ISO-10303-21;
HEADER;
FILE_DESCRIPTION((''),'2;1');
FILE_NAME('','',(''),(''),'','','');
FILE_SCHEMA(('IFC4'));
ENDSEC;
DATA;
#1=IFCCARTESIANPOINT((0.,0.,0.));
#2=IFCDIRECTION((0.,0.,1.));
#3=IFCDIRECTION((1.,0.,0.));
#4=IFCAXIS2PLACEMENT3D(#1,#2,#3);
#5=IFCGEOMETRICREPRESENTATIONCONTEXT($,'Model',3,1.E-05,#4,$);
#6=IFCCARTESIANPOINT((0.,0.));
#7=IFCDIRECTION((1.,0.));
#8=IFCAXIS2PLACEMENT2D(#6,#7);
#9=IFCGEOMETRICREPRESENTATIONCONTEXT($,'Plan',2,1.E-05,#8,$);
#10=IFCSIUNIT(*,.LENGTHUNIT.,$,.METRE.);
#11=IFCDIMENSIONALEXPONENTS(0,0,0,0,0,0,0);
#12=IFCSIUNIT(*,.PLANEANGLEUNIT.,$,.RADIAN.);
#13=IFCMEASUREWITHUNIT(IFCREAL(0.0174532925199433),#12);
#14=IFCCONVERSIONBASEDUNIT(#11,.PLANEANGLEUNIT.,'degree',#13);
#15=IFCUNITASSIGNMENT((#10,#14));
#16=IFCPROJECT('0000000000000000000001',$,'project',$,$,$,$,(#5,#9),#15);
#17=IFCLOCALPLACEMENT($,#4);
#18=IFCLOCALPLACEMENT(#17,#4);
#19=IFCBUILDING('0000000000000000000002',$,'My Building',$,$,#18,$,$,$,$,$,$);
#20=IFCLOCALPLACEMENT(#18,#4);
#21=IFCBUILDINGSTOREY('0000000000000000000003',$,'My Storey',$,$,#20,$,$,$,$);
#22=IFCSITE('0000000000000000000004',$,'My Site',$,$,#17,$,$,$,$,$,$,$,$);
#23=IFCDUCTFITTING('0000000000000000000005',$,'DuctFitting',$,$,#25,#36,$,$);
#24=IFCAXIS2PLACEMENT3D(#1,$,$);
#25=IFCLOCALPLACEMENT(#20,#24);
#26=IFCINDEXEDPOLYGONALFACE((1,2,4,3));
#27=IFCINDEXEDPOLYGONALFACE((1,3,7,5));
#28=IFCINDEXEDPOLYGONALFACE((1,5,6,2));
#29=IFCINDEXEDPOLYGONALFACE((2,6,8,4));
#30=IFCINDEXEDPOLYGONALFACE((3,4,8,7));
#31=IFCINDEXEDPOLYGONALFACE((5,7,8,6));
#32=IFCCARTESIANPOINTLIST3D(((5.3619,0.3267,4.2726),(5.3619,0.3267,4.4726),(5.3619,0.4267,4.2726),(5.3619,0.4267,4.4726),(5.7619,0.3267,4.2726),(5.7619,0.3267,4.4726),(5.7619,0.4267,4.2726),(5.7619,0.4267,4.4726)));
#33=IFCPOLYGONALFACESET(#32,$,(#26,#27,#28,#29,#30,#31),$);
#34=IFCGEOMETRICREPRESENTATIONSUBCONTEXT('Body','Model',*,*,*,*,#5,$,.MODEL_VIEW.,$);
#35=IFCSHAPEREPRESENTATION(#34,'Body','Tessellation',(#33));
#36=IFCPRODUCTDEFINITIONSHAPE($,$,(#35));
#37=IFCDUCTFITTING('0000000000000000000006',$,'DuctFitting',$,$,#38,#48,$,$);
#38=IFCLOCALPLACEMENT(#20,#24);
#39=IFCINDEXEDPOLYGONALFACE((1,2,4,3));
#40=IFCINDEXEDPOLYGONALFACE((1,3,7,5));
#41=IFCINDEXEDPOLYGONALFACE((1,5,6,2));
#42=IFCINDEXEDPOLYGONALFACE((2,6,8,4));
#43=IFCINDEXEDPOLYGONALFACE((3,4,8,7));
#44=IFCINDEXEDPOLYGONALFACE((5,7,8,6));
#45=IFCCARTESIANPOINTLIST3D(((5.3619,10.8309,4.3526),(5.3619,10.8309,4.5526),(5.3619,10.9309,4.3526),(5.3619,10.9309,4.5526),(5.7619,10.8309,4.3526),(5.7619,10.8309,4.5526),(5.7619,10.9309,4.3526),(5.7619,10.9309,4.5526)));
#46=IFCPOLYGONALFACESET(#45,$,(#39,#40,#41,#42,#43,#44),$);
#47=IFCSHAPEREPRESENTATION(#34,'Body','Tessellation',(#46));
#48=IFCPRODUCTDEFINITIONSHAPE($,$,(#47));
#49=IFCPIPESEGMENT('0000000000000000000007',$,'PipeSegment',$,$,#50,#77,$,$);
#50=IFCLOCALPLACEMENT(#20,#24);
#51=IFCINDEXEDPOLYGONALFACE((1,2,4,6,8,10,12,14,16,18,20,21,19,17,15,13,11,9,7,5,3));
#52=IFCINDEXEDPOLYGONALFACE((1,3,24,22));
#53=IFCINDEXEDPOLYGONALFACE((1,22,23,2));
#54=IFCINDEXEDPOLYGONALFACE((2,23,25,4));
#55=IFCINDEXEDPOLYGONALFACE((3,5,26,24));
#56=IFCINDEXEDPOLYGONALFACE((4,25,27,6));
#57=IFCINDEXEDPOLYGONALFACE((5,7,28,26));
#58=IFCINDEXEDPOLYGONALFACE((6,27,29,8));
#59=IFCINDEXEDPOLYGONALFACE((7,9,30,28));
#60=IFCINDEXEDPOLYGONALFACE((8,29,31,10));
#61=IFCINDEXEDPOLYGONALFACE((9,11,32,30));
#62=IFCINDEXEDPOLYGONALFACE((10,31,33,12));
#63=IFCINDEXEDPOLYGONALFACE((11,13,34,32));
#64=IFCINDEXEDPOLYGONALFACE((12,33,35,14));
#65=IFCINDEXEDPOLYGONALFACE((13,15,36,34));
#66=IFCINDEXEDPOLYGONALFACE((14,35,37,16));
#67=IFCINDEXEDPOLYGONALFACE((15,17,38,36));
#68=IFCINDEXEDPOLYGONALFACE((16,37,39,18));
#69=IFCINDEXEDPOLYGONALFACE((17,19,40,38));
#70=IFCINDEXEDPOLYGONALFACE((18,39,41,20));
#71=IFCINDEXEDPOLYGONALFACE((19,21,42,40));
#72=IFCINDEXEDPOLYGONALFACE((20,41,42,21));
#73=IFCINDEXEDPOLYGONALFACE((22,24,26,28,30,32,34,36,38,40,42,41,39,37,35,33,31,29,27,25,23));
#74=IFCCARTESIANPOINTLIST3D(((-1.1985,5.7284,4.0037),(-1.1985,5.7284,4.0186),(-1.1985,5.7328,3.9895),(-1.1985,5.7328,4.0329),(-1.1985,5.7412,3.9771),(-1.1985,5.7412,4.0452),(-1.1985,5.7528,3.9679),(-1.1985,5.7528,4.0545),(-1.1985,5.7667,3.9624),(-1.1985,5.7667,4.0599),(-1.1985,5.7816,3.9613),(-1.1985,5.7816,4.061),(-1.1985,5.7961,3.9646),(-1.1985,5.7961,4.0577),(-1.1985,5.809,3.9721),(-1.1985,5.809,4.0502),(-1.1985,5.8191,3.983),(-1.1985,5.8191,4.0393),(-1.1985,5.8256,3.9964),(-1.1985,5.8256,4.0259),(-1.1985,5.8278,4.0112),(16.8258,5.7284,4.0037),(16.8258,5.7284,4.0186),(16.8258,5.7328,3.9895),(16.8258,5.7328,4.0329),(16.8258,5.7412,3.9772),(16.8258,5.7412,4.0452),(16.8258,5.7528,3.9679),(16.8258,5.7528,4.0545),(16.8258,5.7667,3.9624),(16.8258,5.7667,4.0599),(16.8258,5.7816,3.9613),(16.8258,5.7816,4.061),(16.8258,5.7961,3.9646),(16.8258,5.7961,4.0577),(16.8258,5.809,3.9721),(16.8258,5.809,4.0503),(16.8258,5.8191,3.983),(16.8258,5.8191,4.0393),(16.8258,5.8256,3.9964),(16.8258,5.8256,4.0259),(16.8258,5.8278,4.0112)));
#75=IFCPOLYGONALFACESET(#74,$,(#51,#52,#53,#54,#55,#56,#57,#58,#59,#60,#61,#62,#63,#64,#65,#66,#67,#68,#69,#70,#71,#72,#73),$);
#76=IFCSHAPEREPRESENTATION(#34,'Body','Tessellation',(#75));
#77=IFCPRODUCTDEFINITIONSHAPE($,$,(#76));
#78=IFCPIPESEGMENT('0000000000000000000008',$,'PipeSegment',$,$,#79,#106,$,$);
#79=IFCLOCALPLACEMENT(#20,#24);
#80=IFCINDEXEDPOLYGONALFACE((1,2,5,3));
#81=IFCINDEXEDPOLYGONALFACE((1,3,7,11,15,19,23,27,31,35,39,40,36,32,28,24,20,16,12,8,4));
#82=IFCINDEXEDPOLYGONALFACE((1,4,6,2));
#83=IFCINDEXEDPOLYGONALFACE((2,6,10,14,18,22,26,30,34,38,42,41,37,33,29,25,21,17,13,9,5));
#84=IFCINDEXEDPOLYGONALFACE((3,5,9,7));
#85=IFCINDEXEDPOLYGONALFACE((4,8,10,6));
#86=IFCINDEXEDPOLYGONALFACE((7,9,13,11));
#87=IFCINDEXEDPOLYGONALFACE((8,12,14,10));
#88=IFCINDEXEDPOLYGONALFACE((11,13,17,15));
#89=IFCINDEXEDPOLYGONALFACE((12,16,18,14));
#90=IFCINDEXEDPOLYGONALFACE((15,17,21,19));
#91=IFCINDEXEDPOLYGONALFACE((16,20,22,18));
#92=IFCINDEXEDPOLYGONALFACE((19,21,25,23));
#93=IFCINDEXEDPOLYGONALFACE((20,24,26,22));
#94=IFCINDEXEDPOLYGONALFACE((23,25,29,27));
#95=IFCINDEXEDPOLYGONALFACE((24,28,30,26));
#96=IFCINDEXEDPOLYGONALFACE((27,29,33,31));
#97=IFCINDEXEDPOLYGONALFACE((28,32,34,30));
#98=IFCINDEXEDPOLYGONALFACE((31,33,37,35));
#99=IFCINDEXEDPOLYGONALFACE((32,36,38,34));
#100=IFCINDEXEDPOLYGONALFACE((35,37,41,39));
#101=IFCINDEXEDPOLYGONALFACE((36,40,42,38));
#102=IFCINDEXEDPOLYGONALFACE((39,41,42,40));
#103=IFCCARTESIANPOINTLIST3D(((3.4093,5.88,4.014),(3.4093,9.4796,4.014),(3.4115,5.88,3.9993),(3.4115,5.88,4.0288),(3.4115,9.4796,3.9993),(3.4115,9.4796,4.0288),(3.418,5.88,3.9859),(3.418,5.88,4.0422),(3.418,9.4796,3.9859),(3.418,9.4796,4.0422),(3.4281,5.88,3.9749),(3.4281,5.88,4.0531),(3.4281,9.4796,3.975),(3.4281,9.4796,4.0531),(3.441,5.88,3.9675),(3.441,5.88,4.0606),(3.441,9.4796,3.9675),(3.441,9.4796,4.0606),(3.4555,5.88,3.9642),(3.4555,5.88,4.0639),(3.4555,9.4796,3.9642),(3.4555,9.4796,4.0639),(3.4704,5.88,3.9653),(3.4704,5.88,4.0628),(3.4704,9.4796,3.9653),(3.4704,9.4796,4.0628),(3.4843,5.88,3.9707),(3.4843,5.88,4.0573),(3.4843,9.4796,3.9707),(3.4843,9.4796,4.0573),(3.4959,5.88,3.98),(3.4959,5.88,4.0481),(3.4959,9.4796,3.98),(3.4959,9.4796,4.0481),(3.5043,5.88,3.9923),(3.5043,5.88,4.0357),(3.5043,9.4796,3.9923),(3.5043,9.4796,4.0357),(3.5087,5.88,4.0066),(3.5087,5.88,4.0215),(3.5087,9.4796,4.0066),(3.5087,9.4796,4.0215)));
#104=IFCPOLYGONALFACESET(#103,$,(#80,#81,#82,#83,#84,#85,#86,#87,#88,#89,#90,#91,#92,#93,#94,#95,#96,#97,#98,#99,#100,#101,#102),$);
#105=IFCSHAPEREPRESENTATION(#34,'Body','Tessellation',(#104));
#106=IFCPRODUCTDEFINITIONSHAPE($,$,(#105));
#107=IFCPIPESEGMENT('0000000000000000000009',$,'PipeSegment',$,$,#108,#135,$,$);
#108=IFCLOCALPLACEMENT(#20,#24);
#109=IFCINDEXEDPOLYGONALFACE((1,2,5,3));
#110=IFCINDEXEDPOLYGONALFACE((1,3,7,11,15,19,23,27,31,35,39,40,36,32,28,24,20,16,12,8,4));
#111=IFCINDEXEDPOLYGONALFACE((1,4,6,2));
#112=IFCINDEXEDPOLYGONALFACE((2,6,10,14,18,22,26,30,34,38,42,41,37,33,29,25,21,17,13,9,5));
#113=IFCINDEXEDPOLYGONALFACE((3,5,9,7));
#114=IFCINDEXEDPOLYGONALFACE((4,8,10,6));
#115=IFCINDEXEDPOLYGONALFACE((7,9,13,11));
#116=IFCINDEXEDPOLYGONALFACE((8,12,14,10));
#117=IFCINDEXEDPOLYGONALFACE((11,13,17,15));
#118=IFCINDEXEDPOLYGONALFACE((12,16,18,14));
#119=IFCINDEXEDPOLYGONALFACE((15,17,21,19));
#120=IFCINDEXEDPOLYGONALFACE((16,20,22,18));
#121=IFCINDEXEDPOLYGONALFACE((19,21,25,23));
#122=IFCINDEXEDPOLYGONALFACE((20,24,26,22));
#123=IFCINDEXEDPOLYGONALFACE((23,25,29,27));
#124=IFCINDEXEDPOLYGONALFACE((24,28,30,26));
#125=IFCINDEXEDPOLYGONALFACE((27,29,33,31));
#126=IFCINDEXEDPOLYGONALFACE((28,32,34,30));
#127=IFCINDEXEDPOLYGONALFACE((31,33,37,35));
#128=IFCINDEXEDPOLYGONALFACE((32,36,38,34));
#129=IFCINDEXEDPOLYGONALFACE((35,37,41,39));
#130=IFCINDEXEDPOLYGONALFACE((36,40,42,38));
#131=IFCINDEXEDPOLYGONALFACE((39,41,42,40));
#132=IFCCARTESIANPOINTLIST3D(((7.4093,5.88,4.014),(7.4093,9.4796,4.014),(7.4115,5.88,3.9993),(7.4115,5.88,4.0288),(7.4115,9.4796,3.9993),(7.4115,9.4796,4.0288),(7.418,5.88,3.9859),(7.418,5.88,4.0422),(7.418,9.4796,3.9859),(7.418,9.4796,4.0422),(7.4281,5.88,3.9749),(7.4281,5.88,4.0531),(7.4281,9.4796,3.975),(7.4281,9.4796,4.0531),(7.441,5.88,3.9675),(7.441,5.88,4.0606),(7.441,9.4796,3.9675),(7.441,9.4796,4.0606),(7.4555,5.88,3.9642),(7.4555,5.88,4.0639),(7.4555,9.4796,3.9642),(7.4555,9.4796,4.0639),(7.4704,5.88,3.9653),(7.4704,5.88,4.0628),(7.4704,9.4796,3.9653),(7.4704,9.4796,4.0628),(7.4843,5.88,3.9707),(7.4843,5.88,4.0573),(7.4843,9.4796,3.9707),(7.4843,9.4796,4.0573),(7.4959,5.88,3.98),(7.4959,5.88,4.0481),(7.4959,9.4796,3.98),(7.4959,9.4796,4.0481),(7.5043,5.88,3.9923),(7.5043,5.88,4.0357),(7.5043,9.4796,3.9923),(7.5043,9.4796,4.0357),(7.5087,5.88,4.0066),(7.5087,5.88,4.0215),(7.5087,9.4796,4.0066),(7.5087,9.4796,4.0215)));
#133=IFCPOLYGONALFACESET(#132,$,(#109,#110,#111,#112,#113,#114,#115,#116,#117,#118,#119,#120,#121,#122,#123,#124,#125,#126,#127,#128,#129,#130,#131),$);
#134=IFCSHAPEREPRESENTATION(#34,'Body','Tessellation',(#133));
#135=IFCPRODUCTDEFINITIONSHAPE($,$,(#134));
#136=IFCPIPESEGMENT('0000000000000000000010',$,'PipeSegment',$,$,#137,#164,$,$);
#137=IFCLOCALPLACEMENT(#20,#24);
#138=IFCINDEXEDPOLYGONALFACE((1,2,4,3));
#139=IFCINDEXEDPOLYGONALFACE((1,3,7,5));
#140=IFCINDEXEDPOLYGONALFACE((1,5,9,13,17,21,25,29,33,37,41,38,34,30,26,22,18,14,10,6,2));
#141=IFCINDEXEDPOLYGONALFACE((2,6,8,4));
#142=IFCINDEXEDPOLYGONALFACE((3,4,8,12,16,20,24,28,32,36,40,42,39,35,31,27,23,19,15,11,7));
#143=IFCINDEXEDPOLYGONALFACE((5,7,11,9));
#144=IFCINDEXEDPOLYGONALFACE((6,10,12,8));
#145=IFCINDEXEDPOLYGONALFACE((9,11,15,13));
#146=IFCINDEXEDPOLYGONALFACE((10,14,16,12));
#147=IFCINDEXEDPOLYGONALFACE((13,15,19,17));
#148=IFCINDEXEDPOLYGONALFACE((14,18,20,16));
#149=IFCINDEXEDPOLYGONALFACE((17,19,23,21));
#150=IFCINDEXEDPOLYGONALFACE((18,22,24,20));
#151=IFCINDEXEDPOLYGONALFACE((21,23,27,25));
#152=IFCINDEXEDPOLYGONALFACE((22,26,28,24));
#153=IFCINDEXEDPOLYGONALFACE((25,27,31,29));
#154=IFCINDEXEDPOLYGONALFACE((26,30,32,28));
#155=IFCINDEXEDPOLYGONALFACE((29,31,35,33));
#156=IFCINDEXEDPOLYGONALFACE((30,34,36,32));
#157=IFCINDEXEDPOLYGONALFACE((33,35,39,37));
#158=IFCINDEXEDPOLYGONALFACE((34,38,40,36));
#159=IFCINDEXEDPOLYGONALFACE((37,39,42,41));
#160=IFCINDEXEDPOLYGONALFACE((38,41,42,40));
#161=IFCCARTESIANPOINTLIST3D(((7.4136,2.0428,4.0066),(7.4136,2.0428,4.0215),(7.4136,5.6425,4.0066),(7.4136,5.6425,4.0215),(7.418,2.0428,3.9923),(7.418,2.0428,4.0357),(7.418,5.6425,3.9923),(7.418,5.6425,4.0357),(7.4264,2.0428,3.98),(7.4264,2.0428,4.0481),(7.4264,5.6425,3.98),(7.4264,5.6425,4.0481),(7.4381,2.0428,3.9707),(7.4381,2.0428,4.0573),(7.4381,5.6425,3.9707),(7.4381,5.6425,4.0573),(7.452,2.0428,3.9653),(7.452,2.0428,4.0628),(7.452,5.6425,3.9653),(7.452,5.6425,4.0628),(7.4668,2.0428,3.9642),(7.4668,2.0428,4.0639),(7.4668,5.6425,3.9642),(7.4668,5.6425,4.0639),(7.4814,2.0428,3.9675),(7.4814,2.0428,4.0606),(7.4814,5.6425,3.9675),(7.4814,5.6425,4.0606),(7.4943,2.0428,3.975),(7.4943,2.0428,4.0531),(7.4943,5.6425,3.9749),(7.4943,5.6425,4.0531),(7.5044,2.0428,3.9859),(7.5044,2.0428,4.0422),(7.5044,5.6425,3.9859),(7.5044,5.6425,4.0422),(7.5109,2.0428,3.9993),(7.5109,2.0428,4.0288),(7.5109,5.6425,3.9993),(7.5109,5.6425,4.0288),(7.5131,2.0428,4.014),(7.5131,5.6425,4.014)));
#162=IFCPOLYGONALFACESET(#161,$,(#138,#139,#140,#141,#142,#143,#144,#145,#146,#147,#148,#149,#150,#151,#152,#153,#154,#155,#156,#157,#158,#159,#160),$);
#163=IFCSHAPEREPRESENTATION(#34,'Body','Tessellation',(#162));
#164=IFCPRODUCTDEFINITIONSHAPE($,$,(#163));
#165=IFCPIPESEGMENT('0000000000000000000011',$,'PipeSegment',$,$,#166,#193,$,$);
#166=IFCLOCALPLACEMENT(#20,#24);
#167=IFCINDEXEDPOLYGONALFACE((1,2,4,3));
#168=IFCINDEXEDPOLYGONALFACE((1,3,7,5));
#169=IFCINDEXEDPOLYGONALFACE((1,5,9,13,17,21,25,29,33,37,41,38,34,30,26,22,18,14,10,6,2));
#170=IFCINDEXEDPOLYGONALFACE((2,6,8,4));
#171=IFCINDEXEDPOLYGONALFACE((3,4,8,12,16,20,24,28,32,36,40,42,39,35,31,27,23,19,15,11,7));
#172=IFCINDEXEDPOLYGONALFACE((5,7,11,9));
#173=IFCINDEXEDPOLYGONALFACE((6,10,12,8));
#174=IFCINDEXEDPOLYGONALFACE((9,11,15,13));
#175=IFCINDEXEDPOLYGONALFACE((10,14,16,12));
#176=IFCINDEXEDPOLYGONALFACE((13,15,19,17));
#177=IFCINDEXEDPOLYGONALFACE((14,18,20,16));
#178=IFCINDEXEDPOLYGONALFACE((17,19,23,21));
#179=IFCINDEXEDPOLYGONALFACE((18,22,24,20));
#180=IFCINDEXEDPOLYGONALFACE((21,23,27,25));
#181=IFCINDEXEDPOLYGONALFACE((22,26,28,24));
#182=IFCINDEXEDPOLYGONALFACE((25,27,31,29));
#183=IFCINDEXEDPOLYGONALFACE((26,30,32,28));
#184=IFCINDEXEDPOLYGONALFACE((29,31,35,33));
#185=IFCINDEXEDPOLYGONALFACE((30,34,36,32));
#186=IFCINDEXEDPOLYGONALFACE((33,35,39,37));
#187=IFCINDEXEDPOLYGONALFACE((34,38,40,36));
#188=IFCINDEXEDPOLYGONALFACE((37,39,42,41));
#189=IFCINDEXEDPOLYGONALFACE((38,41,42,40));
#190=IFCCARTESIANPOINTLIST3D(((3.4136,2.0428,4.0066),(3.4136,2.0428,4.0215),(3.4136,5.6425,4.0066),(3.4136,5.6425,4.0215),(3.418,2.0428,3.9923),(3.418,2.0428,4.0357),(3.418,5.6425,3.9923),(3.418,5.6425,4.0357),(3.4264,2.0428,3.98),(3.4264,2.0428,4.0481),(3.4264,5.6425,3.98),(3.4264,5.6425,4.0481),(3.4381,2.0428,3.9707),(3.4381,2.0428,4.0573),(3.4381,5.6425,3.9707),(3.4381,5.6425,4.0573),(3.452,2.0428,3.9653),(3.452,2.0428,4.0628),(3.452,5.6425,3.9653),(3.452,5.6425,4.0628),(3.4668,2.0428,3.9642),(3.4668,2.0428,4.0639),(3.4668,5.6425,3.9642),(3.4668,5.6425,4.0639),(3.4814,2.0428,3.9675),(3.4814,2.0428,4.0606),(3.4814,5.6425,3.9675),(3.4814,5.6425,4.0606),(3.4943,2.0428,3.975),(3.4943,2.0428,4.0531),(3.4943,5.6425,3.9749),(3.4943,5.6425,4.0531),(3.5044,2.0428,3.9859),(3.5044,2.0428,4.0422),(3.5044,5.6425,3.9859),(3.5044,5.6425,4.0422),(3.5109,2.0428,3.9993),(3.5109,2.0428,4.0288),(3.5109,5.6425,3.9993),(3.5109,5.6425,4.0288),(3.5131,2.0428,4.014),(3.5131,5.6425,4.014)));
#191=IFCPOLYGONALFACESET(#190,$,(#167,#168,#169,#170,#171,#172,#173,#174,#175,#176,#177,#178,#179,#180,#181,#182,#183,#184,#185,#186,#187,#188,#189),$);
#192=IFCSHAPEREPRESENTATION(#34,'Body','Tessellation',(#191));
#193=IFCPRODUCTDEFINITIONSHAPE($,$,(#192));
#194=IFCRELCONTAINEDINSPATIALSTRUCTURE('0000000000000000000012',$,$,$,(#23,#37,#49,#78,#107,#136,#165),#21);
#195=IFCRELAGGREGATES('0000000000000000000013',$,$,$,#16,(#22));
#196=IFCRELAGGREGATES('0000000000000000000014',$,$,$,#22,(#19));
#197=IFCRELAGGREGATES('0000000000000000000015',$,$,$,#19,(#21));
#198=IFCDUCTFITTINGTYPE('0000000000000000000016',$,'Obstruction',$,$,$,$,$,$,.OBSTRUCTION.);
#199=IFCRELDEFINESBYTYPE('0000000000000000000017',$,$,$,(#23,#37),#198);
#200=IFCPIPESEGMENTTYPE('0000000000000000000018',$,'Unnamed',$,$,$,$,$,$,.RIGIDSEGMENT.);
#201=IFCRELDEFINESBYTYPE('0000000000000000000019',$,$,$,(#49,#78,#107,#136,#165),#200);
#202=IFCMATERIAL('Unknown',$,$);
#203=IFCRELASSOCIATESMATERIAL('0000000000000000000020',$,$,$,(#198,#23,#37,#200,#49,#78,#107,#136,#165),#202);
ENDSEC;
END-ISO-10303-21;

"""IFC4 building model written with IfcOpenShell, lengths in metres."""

from ifc_helpers import new_model, entity, si_unit, converted_unit, frame, origin_with_axes, origin_2d_with_axis, place, context, subcontext, project, spatial, rectangle, circle, extrude, material, material_profile, profile_set, profile_usage, type_object, element, save


model = new_model("IFC4")

# Units and contexts
model_context = context("Model", 3, precision=1e-05, world=origin_with_axes())
plan_context = context("Plan", 2, precision=1e-05, world=origin_2d_with_axis())
body_context = subcontext(model_context, "Body", "Model", "MODEL_VIEW")
ifc_project = project(units=[si_unit("LENGTHUNIT", "METRE"), converted_unit("PLANEANGLEUNIT", "degree", entity("IfcReal", 0.0174532925199433), si_unit("PLANEANGLEUNIT", "RADIAN"), dimensions=[0, 0, 0, 0, 0, 0, 0])], contexts=[model_context, plan_context])

# Site, building, storey
site_placement = place(None, origin_with_axes())
site = spatial("IfcSite", under=ifc_project, at=site_placement, Name="My Site")
building_placement = place(site_placement, origin_with_axes())
building = spatial("IfcBuilding", under=site, at=building_placement, Name="My Building")
storey_placement = place(building_placement, origin_with_axes())
storey = spatial("IfcBuildingStorey", under=building, at=storey_placement, Name="My Storey")

# Shared definitions
ifc_material = material(Name="Unknown")

# Duct fittings
ifc_material_profile_1 = material_profile(ifc_material, rectangle(XDim=0.4, YDim=0.2))
ifc_profile_set_1 = profile_set([ifc_material_profile_1])
ifc_profile_usage_1 = profile_usage(ifc_profile_set_1, cardinal=5)
duct_fitting_type_1 = type_object("IfcDuctFittingType", Name="Obstruction", PredefinedType="OBSTRUCTION", material=ifc_profile_set_1)
duct_fitting_1_placement = place(storey_placement, frame((5.5619, 0.3267, 4.3726), z_axis=(0.0, 1.0, 0.0), x_axis=(-1.0, 0.0, 0.0)))
element("IfcDuctFitting", 1, at=duct_fitting_1_placement, inside=storey, type_object=duct_fitting_type_1, material=ifc_profile_usage_1, Name="DuctFitting", context=body_context, shape_type="SweptSolid", body=[
    extrude(rectangle(XDim=0.4, YDim=0.2), origin_with_axes(), (0.0, 0.0, 1.0), 0.1),
])
ifc_profile_usage_2 = profile_usage(ifc_profile_set_1, cardinal=5)
duct_fitting_2_placement = place(storey_placement, frame((5.5619, 10.9309, 4.4526), z_axis=(0.0, -1.0, 0.0), x_axis=(1.0, 0.0, 0.0)))
element("IfcDuctFitting", 2, at=duct_fitting_2_placement, inside=storey, type_object=duct_fitting_type_1, material=ifc_profile_usage_2, Name="DuctFitting", context=body_context, shape_type="SweptSolid", body=[
    extrude(rectangle(XDim=0.4, YDim=0.2), origin_with_axes(), (0.0, 0.0, 1.0), 0.1),
])

# Pipe segments
ifc_material_profile_2 = material_profile(ifc_material, circle(Radius=0.05))
ifc_profile_set_2 = profile_set([ifc_material_profile_2])
ifc_profile_usage_3 = profile_usage(ifc_profile_set_2, cardinal=5)
pipe_segment_type = type_object("IfcPipeSegmentType", Name="Unnamed", PredefinedType="RIGIDSEGMENT", material=ifc_profile_set_2)
pipe_segment_1_placement = place(storey_placement, frame((-1.1985, 5.7778, 4.0112), z_axis=(1.0, 0.0, 0.0), x_axis=(0.0, 1.0, 0.0)))
element("IfcPipeSegment", 3, at=pipe_segment_1_placement, inside=storey, type_object=pipe_segment_type, material=ifc_profile_usage_3, Name="PipeSegment", context=body_context, shape_type="SweptSolid", body=[
    extrude(circle(Radius=0.05), origin_with_axes(), (0.0, 0.0, 1.0), 18.0244),
])
ifc_profile_usage_4 = profile_usage(ifc_profile_set_2, cardinal=5)
pipe_segment_2_placement = place(storey_placement, frame((3.4593, 5.88, 4.014), z_axis=(0.0, 1.0, 0.0), x_axis=(-1.0, 0.0, 0.0)))
element("IfcPipeSegment", 4, at=pipe_segment_2_placement, inside=storey, type_object=pipe_segment_type, material=ifc_profile_usage_4, Name="PipeSegment", context=body_context, shape_type="SweptSolid", body=[
    extrude(circle(Radius=0.05), origin_with_axes(), (0.0, 0.0, 1.0), 3.5996),
])
ifc_profile_usage_5 = profile_usage(ifc_profile_set_2, cardinal=5)
pipe_segment_3_placement = place(storey_placement, frame((7.4593, 5.88, 4.014), z_axis=(0.0, 1.0, 0.0), x_axis=(-1.0, 0.0, 0.0)))
element("IfcPipeSegment", 5, at=pipe_segment_3_placement, inside=storey, type_object=pipe_segment_type, material=ifc_profile_usage_5, Name="PipeSegment", context=body_context, shape_type="SweptSolid", body=[
    extrude(circle(Radius=0.05), origin_with_axes(), (0.0, 0.0, 1.0), 3.5996),
])
ifc_profile_usage_6 = profile_usage(ifc_profile_set_2, cardinal=5)
pipe_segment_4_placement = place(storey_placement, frame((7.4631, 5.6425, 4.014), z_axis=(0.0, -1.0, 0.0), x_axis=(1.0, 0.0, 0.0)))
element("IfcPipeSegment", 6, at=pipe_segment_4_placement, inside=storey, type_object=pipe_segment_type, material=ifc_profile_usage_6, Name="PipeSegment", context=body_context, shape_type="SweptSolid", body=[
    extrude(circle(Radius=0.05), origin_with_axes(), (0.0, 0.0, 1.0), 3.5996),
])
ifc_profile_usage_7 = profile_usage(ifc_profile_set_2, cardinal=5)
pipe_segment_5_placement = place(storey_placement, frame((3.4631, 5.6425, 4.014), z_axis=(0.0, -1.0, 0.0), x_axis=(1.0, 0.0, 0.0)))
element("IfcPipeSegment", 7, at=pipe_segment_5_placement, inside=storey, type_object=pipe_segment_type, material=ifc_profile_usage_7, Name="PipeSegment", context=body_context, shape_type="SweptSolid", body=[
    extrude(circle(Radius=0.05), origin_with_axes(), (0.0, 0.0, 1.0), 3.5996),
])

save(model, "model.ifc")
